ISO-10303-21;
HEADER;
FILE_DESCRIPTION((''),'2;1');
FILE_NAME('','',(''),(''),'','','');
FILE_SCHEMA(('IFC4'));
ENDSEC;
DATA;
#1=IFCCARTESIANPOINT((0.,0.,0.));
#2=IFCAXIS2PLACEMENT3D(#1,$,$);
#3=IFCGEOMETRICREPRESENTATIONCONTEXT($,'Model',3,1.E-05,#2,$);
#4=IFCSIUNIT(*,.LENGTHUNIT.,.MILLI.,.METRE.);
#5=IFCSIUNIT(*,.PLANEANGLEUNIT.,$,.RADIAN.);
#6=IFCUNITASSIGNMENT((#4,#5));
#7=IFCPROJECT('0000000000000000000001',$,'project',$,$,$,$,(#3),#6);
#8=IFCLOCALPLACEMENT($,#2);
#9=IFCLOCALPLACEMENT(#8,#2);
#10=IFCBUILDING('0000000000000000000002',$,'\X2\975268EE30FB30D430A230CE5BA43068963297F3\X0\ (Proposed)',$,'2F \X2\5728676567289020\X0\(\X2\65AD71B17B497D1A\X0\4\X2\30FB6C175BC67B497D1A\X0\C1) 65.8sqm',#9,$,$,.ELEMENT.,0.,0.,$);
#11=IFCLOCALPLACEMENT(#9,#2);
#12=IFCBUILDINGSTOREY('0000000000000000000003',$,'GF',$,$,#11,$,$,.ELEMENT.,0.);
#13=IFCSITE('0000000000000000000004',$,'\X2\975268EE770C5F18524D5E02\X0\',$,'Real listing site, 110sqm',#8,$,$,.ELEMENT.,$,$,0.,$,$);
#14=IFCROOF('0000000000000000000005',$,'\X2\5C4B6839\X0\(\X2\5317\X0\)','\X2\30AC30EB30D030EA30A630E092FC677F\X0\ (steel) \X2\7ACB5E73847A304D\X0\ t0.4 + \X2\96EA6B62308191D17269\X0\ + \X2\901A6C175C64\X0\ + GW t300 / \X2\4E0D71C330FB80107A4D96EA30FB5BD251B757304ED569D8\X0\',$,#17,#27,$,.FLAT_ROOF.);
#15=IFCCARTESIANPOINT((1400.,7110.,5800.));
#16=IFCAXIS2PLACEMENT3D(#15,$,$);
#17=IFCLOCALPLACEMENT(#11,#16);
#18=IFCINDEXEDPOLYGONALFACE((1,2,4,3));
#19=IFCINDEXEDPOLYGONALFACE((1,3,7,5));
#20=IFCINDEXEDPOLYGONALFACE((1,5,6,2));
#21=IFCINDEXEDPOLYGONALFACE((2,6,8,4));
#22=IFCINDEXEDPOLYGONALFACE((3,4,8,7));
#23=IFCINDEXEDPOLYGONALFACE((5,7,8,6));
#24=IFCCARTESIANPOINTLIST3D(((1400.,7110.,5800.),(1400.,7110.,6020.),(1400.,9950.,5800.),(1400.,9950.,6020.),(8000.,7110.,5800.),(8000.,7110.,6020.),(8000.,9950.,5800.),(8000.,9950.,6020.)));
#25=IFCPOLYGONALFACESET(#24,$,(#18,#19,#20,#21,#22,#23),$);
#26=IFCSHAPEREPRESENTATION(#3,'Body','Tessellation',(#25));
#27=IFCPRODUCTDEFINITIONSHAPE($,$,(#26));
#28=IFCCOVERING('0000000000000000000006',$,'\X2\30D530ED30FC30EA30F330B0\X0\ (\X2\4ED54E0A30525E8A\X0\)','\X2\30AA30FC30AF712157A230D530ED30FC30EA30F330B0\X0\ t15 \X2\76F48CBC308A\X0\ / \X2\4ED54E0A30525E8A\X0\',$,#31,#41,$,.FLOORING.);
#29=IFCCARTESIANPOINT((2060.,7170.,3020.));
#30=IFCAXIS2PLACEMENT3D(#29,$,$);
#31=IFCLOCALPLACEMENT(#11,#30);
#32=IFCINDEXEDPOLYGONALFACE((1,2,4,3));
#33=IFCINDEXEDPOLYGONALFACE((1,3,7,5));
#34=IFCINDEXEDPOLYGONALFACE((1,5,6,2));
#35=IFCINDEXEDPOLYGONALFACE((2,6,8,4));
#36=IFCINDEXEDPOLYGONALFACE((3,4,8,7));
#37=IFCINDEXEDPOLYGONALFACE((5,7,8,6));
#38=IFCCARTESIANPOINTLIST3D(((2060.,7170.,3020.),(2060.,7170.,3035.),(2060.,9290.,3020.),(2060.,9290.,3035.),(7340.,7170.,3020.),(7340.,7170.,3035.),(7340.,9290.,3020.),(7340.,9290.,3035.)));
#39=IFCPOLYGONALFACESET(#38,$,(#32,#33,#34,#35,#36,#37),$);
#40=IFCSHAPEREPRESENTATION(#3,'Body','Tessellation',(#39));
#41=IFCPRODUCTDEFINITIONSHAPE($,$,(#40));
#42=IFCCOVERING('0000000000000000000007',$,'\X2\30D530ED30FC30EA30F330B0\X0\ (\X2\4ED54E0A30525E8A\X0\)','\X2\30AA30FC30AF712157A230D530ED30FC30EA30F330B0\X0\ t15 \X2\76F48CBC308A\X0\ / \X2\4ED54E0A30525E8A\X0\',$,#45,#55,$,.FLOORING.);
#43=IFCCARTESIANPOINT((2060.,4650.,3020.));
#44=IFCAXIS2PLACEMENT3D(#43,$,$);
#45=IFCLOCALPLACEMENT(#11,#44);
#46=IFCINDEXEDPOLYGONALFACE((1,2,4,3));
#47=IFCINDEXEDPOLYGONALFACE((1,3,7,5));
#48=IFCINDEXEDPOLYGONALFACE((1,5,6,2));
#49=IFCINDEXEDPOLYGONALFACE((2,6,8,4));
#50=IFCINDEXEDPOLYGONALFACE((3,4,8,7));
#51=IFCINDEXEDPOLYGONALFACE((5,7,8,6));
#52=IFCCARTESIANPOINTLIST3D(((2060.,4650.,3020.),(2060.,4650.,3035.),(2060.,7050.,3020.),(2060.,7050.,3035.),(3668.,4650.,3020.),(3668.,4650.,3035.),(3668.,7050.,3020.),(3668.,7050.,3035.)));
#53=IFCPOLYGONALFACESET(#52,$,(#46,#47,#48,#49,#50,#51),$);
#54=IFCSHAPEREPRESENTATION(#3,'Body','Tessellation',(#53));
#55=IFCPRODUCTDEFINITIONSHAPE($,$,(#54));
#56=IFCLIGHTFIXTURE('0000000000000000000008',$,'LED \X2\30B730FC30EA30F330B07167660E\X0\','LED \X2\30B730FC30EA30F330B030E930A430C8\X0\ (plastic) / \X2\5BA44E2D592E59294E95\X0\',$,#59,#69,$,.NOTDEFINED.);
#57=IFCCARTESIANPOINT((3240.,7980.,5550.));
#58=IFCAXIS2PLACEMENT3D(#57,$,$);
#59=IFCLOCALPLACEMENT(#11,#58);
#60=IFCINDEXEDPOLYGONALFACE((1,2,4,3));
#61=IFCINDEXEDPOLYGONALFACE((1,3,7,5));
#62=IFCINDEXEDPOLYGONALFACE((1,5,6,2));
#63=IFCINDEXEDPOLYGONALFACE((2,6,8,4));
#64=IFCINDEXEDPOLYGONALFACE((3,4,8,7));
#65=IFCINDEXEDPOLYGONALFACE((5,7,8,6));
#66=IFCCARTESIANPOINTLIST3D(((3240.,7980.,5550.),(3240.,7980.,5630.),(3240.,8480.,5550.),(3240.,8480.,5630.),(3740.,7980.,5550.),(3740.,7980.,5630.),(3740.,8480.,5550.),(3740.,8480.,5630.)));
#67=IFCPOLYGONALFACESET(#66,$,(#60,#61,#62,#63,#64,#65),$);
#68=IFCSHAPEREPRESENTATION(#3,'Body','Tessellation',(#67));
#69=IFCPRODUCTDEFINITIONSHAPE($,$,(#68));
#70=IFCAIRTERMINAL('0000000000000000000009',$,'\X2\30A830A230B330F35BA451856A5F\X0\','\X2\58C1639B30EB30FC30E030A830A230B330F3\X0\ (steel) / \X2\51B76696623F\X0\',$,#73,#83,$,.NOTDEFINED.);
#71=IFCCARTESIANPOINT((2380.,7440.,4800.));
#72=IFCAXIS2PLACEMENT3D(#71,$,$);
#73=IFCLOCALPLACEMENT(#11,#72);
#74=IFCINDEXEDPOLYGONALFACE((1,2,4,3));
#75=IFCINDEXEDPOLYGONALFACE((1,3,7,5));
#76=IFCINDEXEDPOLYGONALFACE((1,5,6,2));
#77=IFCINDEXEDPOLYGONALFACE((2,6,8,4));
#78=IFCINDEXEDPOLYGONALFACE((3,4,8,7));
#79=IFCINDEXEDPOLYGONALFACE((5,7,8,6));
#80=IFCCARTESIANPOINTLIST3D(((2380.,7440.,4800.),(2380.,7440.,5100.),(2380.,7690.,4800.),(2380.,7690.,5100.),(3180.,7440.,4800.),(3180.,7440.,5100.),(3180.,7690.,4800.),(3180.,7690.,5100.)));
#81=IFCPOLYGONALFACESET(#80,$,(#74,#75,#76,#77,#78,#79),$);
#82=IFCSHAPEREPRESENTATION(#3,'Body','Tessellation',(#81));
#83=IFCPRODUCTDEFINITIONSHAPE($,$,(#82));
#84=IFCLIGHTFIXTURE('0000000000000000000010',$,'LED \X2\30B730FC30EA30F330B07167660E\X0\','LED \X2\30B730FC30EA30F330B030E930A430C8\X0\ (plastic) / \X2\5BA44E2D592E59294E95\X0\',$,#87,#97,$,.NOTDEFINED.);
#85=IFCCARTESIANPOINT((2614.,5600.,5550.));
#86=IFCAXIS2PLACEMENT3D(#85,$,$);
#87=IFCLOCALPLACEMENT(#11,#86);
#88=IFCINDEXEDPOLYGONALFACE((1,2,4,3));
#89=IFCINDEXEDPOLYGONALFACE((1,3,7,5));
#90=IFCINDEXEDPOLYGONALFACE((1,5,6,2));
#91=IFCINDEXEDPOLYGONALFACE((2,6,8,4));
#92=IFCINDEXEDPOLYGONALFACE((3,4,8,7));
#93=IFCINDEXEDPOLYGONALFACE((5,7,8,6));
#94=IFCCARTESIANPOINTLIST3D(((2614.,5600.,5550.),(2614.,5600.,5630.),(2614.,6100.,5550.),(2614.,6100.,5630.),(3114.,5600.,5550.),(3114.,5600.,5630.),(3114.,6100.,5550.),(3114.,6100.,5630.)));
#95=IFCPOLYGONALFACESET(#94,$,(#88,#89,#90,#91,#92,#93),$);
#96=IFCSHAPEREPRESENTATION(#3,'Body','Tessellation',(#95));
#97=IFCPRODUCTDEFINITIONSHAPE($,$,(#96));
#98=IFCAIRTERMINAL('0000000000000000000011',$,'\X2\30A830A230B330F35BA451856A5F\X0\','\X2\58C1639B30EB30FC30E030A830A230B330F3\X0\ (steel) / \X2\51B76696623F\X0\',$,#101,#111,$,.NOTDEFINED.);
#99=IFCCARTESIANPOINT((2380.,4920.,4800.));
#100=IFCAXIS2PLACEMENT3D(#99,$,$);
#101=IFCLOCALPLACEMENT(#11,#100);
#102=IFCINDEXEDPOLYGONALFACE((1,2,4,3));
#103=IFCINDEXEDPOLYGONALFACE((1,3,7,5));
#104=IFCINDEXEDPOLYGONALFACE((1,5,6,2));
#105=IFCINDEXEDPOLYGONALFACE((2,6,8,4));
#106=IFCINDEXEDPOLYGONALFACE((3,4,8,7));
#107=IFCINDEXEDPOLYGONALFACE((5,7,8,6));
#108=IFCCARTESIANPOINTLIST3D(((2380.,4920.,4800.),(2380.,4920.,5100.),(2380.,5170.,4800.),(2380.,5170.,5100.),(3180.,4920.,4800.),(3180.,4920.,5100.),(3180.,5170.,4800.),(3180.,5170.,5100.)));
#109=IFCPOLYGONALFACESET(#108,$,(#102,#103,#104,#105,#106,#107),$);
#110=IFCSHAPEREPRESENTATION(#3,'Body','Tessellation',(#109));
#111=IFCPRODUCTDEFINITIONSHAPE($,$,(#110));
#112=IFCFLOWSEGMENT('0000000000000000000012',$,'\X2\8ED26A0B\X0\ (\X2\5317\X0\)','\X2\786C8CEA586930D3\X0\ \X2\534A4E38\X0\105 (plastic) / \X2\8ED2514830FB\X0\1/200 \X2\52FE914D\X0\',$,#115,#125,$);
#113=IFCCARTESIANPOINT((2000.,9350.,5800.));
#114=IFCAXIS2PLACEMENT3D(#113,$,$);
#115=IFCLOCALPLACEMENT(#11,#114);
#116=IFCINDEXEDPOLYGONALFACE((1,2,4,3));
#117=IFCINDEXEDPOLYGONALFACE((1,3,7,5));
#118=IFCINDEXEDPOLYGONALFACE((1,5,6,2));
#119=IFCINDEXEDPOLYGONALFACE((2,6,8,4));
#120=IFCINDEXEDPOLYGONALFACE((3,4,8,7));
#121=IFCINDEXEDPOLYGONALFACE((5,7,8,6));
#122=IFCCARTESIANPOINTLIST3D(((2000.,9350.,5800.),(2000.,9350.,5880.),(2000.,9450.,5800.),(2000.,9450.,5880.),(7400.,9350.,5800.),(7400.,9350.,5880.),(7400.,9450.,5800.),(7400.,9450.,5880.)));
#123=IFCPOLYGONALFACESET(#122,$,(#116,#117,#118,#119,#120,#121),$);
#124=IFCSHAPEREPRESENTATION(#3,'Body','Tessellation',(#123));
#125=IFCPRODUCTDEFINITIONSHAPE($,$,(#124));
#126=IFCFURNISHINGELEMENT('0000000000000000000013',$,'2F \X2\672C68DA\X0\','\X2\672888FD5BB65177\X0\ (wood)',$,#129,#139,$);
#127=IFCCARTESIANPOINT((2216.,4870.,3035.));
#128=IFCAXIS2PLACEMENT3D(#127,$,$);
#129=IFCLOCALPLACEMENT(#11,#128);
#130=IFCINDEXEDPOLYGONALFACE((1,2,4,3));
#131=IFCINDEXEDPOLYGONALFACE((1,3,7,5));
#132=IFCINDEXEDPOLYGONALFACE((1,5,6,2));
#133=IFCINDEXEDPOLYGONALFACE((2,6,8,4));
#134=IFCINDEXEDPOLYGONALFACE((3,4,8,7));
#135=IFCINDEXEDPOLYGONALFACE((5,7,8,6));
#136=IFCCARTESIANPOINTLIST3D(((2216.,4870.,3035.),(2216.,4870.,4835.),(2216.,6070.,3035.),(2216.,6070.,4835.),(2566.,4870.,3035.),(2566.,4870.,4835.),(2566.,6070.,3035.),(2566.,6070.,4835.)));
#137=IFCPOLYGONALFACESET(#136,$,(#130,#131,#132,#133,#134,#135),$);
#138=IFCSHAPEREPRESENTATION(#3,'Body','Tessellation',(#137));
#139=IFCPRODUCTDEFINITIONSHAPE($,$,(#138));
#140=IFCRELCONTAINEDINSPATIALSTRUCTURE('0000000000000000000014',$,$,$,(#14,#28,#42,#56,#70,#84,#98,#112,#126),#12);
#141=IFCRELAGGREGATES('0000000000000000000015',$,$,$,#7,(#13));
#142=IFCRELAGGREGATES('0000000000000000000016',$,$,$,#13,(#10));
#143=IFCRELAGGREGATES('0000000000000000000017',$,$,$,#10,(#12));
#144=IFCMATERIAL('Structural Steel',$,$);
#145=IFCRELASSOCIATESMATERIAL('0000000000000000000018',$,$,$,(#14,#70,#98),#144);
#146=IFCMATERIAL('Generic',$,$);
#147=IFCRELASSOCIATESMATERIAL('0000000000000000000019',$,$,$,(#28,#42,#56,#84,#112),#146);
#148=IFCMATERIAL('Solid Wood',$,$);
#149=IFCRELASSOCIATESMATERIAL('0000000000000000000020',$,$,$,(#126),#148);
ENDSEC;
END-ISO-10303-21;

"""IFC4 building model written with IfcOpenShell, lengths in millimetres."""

from ifc_helpers import new_model, si_unit, frame, frame_2d, origin, place, context, project, spatial, rectangle, extrude, material, element, save


model = new_model("IFC4")

# Units and contexts
model_context = context("Model", 3, precision=1e-05, world=origin())
ifc_project = project(units=[si_unit("LENGTHUNIT", "METRE", prefix="MILLI"), si_unit("PLANEANGLEUNIT", "RADIAN")], contexts=[model_context])

# Site, building, storey
site_placement = place(None, origin())
site = spatial("IfcSite", under=ifc_project, at=site_placement, Name="青森県弘前市", ObjectType="Real listing site, 110sqm", CompositionType="ELEMENT", RefElevation=0.0)
building_placement = place(site_placement, origin())
building = spatial("IfcBuilding", under=site, at=building_placement, Name="青森・ピアノ室と防音 (Proposed)", ObjectType="2F 在来木造(断熱等級4・気密等級C1) 65.8sqm", CompositionType="ELEMENT", ElevationOfRefHeight=0.0, ElevationOfTerrain=0.0)
storey_placement = place(building_placement, origin())
storey = spatial("IfcBuildingStorey", under=building, at=storey_placement, Name="GF", CompositionType="ELEMENT", Elevation=0.0)

# Shared definitions
ifc_material_1 = material(Name="Solid Wood")

# Roof
ifc_material_2 = material(Name="Structural Steel")
for number, where, name in (
    (1, (1400.0, 7110.0, 5800.0), "屋根(北)"),
):
    element("IfcRoof", number, at=place(storey_placement, frame(where)), inside=storey, material=ifc_material_2, Name=name, Description="ガルバリウム鋼板 (steel) 立平葺き t0.4 + 雪止め金物 + 通気層 + GW t300 / 不燃・耐積雪・寒冷地仕様", PredefinedType="FLAT_ROOF", context=model_context, shape_type="SweptSolid", body=[
        extrude(rectangle(XDim=6600.0, YDim=2840.0, at=frame_2d((3300.0, 1420.0))), frame((1400.0, 7110.0, 5800.0)), (0.0, 0.0, 1.0), 220.0),
    ])

# Coverings
ifc_material_3 = material(Name="Generic")
covering_1_placement = place(storey_placement, frame((2060.0, 7170.0, 3020.0)))
element("IfcCovering", 2, at=covering_1_placement, inside=storey, material=ifc_material_3, Name="フローリング (仕上げ床)", Description="オーク無垢フローリング t15 直貼り / 仕上げ床", PredefinedType="FLOORING", context=model_context, shape_type="SweptSolid", body=[
    extrude(rectangle(XDim=5280.0, YDim=2120.0, at=frame_2d((2640.0, 1060.0))), frame((2060.0, 7170.0, 3020.0)), (0.0, 0.0, 1.0), 15.0),
])
covering_2_placement = place(storey_placement, frame((2060.0, 4650.0, 3020.0)))
element("IfcCovering", 3, at=covering_2_placement, inside=storey, material=ifc_material_3, Name="フローリング (仕上げ床)", Description="オーク無垢フローリング t15 直貼り / 仕上げ床", PredefinedType="FLOORING", context=model_context, shape_type="SweptSolid", body=[
    extrude(rectangle(XDim=1608.0, YDim=2400.0, at=frame_2d((804.0, 1200.0))), frame((2060.0, 4650.0, 3020.0)), (0.0, 0.0, 1.0), 15.0),
])

# Light fixture
light_fixture_1_placement = place(storey_placement, frame((3240.0, 7980.0, 5550.0)))
element("IfcLightFixture", 4, at=light_fixture_1_placement, inside=storey, material=ifc_material_3, Name="LED シーリング照明", Description="LED シーリングライト (plastic) / 室中央天井", PredefinedType="NOTDEFINED", context=model_context, shape_type="SweptSolid", body=[
    extrude(rectangle(XDim=500.0, YDim=500.0, at=frame_2d((250.0, 250.0))), frame((3240.0, 7980.0, 5550.0)), (0.0, 0.0, 1.0), 80.0),
])

# Air terminal
air_terminal_1_placement = place(storey_placement, frame((2380.0, 7440.0, 4800.0)))
element("IfcAirTerminal", 5, at=air_terminal_1_placement, inside=storey, material=ifc_material_2, Name="エアコン室内機", Description="壁掛ルームエアコン (steel) / 冷暖房", PredefinedType="NOTDEFINED", context=model_context, shape_type="SweptSolid", body=[
    extrude(rectangle(XDim=800.0, YDim=250.0, at=frame_2d((400.0, 125.0))), frame((2380.0, 7440.0, 4800.0)), (0.0, 0.0, 1.0), 300.0),
])

# Light fixture
light_fixture_2_placement = place(storey_placement, frame((2614.0, 5600.0, 5550.0)))
element("IfcLightFixture", 6, at=light_fixture_2_placement, inside=storey, material=ifc_material_3, Name="LED シーリング照明", Description="LED シーリングライト (plastic) / 室中央天井", PredefinedType="NOTDEFINED", context=model_context, shape_type="SweptSolid", body=[
    extrude(rectangle(XDim=500.0, YDim=500.0, at=frame_2d((250.0, 250.0))), frame((2614.0, 5600.0, 5550.0)), (0.0, 0.0, 1.0), 80.0),
])

# Air terminal
air_terminal_2_placement = place(storey_placement, frame((2380.0, 4920.0, 4800.0)))
element("IfcAirTerminal", 7, at=air_terminal_2_placement, inside=storey, material=ifc_material_2, Name="エアコン室内機", Description="壁掛ルームエアコン (steel) / 冷暖房", PredefinedType="NOTDEFINED", context=model_context, shape_type="SweptSolid", body=[
    extrude(rectangle(XDim=800.0, YDim=250.0, at=frame_2d((400.0, 125.0))), frame((2380.0, 4920.0, 4800.0)), (0.0, 0.0, 1.0), 300.0),
])

# Flow segment
flow_segment_placement = place(storey_placement, frame((2000.0, 9350.0, 5800.0)))
element("IfcFlowSegment", 8, at=flow_segment_placement, inside=storey, material=ifc_material_3, Name="軒樋 (北)", Description="硬質塩ビ 半丸105 (plastic) / 軒先・1/200 勾配", context=model_context, shape_type="SweptSolid", body=[
    extrude(rectangle(XDim=5400.0, YDim=100.0, at=frame_2d((2700.0, 50.0))), frame((2000.0, 9350.0, 5800.0)), (0.0, 0.0, 1.0), 80.0),
])

# Furnishing element
furnishing_placement = place(storey_placement, frame((2216.0, 4870.0, 3035.0)))
element("IfcFurnishingElement", 9, at=furnishing_placement, inside=storey, material=ifc_material_1, Name="2F 本棚", Description="木製家具 (wood)", context=model_context, shape_type="SweptSolid", body=[
    extrude(rectangle(XDim=350.0, YDim=1200.0, at=frame_2d((175.0, 600.0))), frame((2216.0, 4870.0, 3035.0)), (0.0, 0.0, 1.0), 1800.0),
])

save(model, "model.ifc")
